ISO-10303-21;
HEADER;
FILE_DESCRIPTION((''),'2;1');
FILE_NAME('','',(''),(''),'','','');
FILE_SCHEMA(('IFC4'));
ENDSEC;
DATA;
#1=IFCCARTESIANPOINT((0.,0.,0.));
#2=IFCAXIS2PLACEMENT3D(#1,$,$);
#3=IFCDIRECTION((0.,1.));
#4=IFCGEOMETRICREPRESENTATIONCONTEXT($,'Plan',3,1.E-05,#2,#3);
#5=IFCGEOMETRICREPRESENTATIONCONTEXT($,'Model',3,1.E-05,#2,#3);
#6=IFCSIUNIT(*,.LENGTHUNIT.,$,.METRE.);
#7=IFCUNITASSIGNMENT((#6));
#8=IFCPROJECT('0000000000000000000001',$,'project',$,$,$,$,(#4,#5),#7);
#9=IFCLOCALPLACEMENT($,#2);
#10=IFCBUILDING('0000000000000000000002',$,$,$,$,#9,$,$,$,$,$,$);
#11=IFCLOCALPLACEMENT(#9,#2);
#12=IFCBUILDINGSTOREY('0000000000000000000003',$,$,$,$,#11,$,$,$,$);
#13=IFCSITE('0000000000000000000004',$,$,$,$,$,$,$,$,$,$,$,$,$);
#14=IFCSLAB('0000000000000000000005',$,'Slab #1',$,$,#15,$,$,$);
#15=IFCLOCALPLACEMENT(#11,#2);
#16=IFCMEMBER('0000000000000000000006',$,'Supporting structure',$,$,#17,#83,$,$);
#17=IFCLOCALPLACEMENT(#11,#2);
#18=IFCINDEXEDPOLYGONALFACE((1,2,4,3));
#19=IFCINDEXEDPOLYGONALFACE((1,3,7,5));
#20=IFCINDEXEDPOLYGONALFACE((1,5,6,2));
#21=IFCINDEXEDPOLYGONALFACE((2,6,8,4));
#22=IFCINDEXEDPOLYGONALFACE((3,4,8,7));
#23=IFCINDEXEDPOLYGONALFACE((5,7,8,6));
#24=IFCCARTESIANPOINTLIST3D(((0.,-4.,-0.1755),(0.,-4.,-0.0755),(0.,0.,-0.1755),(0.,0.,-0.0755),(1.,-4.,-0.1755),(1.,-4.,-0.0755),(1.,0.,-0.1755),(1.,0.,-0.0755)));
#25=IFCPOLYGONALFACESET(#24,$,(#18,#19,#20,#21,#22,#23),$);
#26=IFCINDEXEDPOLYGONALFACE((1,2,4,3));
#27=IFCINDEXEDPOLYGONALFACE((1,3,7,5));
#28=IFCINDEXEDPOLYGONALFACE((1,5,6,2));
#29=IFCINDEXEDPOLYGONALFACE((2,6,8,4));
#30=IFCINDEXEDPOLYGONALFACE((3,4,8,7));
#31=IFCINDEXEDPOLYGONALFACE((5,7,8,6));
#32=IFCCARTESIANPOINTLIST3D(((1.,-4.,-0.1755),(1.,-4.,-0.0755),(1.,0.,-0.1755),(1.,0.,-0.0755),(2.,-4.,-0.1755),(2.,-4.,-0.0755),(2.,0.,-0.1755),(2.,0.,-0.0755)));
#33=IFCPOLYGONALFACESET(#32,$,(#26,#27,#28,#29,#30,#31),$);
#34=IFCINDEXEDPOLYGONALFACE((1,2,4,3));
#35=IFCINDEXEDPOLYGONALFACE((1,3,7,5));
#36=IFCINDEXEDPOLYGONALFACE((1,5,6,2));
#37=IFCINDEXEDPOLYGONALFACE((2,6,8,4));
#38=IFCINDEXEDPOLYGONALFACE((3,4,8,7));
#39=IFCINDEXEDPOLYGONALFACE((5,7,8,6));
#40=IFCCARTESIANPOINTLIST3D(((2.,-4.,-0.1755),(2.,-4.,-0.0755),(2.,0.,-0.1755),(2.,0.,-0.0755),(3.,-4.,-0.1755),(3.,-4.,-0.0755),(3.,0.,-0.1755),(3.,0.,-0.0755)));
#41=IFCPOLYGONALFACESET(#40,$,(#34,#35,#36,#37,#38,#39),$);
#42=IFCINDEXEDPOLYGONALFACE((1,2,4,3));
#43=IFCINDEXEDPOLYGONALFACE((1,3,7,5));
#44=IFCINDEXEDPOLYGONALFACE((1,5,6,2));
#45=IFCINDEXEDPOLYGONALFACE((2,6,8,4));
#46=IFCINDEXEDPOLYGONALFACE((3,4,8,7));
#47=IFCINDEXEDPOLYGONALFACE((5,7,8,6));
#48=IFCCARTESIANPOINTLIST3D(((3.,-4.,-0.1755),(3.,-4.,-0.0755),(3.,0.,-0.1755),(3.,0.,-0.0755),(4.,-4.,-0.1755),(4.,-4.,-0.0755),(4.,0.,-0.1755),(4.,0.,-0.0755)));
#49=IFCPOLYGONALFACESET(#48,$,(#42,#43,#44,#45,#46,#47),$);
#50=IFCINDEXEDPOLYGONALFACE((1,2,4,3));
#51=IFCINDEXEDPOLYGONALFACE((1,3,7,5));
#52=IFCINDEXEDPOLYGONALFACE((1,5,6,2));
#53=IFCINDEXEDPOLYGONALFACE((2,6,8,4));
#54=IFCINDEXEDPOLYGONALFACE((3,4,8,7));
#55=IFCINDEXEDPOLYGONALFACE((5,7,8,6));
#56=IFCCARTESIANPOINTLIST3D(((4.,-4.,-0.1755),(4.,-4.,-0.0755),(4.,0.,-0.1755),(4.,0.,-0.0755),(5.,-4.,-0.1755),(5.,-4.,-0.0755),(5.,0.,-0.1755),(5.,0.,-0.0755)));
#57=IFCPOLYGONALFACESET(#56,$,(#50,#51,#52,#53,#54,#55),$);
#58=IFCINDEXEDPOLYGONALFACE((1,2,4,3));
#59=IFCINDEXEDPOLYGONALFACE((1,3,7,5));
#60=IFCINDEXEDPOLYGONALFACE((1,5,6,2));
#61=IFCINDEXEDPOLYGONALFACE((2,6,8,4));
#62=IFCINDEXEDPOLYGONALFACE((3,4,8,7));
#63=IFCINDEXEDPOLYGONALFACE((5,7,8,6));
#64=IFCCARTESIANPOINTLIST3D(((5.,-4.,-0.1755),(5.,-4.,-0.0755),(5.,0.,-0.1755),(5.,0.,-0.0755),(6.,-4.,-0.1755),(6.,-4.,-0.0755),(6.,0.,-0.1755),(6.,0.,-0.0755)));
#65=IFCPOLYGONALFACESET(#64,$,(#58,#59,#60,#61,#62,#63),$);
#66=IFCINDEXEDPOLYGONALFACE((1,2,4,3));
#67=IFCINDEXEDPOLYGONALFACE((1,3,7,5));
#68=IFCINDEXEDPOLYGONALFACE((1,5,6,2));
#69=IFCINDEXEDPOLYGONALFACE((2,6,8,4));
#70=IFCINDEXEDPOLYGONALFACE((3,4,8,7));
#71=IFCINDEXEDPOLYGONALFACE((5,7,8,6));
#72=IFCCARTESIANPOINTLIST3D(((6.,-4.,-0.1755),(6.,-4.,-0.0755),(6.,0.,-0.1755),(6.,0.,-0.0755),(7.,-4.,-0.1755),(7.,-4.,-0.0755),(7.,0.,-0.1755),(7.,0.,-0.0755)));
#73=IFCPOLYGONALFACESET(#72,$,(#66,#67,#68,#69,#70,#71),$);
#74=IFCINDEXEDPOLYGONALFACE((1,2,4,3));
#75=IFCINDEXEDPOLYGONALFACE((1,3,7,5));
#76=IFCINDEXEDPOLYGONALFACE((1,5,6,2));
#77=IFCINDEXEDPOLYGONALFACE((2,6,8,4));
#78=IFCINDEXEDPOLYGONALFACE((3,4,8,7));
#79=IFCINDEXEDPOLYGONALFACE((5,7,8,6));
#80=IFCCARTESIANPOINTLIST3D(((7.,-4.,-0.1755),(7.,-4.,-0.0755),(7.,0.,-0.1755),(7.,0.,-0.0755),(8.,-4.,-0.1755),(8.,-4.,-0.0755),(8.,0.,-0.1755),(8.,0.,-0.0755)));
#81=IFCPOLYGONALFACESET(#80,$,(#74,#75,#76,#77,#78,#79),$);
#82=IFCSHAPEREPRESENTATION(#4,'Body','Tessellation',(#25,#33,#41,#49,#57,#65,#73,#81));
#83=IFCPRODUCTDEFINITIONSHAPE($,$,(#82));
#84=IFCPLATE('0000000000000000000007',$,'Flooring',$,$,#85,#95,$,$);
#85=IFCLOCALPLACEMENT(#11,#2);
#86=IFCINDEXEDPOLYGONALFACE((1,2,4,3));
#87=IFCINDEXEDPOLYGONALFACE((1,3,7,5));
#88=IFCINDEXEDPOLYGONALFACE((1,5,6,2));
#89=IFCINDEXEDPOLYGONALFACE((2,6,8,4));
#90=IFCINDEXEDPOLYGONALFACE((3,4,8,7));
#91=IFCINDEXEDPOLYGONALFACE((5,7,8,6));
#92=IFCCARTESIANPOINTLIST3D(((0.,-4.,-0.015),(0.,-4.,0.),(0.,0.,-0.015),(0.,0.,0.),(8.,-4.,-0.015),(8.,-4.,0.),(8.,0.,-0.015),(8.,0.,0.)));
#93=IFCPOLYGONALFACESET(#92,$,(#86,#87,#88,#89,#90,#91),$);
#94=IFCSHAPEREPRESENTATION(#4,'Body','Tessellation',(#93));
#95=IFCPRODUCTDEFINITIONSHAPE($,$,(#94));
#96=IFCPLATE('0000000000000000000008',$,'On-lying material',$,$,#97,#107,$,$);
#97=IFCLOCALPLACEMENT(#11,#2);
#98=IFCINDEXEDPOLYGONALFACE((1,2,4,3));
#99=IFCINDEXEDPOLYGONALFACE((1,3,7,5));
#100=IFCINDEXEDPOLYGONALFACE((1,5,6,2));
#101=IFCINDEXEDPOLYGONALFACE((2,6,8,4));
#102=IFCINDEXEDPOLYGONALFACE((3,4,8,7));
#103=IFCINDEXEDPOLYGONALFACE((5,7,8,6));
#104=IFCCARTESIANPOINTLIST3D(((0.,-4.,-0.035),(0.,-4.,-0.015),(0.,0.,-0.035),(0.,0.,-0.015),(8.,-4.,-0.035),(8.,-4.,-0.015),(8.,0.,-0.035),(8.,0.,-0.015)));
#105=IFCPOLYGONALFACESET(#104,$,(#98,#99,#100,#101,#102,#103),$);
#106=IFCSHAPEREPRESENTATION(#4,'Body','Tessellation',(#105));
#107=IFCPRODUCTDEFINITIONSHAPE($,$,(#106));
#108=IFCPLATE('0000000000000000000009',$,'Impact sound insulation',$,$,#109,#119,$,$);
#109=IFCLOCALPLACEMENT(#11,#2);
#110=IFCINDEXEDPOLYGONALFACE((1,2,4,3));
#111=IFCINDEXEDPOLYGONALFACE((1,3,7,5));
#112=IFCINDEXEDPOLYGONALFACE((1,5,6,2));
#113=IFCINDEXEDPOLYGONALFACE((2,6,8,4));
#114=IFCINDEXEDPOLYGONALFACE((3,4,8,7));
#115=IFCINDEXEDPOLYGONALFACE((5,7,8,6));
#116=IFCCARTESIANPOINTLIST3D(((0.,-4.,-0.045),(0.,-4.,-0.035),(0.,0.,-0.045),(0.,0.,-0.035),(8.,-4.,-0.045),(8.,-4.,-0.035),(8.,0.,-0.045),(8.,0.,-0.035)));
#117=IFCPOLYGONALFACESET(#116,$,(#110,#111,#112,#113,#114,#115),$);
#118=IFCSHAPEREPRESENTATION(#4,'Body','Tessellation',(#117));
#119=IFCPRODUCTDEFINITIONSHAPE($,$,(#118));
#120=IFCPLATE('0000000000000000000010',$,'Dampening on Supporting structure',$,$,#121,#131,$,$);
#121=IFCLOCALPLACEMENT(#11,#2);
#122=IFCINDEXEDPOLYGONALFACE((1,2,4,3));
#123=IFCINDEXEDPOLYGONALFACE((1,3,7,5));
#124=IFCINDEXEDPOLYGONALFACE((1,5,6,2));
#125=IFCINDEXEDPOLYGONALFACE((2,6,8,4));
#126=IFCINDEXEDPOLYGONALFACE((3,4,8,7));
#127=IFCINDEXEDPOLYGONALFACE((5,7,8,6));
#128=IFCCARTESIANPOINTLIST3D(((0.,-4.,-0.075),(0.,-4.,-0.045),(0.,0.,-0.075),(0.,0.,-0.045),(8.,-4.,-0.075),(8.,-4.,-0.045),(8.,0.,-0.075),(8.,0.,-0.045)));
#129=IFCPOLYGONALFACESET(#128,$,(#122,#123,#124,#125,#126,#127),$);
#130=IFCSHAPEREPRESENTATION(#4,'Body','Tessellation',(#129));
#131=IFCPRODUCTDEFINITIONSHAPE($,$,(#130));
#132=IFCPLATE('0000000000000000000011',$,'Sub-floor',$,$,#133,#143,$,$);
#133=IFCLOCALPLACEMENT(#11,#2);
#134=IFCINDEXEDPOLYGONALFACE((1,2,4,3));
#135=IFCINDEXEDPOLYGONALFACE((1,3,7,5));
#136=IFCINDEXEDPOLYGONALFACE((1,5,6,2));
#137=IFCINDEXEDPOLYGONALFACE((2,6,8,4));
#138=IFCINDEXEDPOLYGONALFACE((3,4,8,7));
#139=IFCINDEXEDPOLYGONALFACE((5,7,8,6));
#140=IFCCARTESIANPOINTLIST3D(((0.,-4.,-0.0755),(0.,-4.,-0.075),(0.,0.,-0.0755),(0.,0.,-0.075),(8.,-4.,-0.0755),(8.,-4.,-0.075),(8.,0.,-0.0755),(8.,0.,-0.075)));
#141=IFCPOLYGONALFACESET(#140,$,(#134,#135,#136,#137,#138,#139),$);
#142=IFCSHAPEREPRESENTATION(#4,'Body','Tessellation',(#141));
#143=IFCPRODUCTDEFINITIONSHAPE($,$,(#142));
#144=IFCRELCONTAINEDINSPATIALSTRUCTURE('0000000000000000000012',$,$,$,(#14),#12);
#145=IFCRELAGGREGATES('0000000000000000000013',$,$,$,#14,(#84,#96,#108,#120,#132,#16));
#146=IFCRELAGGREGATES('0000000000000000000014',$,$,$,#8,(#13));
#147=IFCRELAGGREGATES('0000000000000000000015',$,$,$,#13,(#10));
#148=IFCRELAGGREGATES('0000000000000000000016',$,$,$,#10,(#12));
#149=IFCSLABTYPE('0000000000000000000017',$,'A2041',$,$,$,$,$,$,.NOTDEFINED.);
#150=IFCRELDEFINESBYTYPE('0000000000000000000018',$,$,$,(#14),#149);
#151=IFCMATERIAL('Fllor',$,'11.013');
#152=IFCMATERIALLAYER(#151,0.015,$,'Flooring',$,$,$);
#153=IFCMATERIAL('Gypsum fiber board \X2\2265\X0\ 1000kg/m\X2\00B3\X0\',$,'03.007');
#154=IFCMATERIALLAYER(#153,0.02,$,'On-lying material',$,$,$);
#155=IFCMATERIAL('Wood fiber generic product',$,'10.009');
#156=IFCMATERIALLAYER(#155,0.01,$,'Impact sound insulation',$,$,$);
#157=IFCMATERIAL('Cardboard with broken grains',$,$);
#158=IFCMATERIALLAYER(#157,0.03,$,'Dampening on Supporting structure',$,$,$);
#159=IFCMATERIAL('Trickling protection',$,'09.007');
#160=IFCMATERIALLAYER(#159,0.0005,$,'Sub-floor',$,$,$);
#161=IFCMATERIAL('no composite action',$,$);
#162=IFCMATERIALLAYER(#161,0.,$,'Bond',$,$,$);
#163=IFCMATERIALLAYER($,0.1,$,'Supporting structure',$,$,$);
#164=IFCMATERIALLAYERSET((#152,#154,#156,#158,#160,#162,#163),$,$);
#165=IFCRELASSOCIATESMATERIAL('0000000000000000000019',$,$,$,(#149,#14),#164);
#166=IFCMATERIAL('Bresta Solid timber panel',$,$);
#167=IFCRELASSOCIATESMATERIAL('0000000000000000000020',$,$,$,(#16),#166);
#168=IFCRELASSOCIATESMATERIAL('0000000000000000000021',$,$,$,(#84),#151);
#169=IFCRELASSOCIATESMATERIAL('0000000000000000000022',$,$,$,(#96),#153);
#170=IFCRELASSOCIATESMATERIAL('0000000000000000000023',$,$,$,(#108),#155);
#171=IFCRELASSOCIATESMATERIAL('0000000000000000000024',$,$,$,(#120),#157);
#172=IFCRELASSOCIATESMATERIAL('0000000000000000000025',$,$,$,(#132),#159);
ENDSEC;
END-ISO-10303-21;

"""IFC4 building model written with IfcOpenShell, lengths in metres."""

from ifc_helpers import new_model, si_unit, direction, frame, frame_2d, origin, origin_with_axes, place, context, project, spatial, rectangle, extrude, material, layer, layer_set, type_object, element, aggregate, save


model = new_model("IFC4")

# Units and contexts
plan_context = context("Plan", 3, precision=1e-05, world=origin(), true_north=direction((0.0, 1.0)))
model_context = context("Model", 3, precision=1e-05, world=origin(), true_north=direction((0.0, 1.0)))
ifc_project = project(units=[si_unit("LENGTHUNIT", "METRE")], contexts=[plan_context, model_context])

# Site, building, storey
site = spatial("IfcSite", under=ifc_project)
building_placement = place(None, origin())
building = spatial("IfcBuilding", under=site, at=building_placement)
storey_placement = place(building_placement, origin())
storey = spatial("IfcBuildingStorey", under=building, at=storey_placement)

# Slab, member, plates
ifc_material_1 = material(Name="Fllor", Category="11.013")
ifc_layer_1 = layer(ifc_material_1, 0.015, Name="Flooring")
ifc_material_2 = material(Name="Gypsum fiber board ≥ 1000kg/m³", Category="03.007")
ifc_layer_2 = layer(ifc_material_2, 0.02, Name="On-lying material")
ifc_material_3 = material(Name="Wood fiber generic product", Category="10.009")
ifc_layer_3 = layer(ifc_material_3, 0.01, Name="Impact sound insulation")
ifc_material_4 = material(Name="Cardboard with broken grains")
ifc_layer_4 = layer(ifc_material_4, 0.03, Name="Dampening on Supporting structure")
ifc_material_5 = material(Name="Trickling protection", Category="09.007")
ifc_layer_5 = layer(ifc_material_5, 0.0005, Name="Sub-floor")
ifc_material_6 = material(Name="no composite action")
ifc_layer_6 = layer(ifc_material_6, 0.0, Name="Bond")
ifc_layer_7 = layer(None, 0.1, Name="Supporting structure")
ifc_layer_set = layer_set([ifc_layer_1, ifc_layer_2, ifc_layer_3, ifc_layer_4, ifc_layer_5, ifc_layer_6, ifc_layer_7])
slab_type = type_object("IfcSlabType", Name="A2041", PredefinedType="NOTDEFINED", material=ifc_layer_set)
slab_placement = place(None, frame((0.0, 0.0, 0.0), z_axis=(0.0, 0.0, -1.0), x_axis=(1.0, 0.0, 0.0)))
slab = element("IfcSlab", 1, at=slab_placement, inside=storey, type_object=slab_type, material=ifc_layer_set, Name="Slab #1")
ifc_material_7 = material(Name="Bresta Solid timber panel")
member_placement = place(slab_placement, origin())
member = element("IfcMember", 2, at=member_placement, material=ifc_material_7, Name="Supporting structure", context=plan_context, shape_type="SweptSolid", body=[
    extrude(rectangle(XDim=1.0, YDim=0.1, at=frame_2d((0.5, 0.05), x_axis=(1.0, 0.0))), frame((0.0, 4.0, 0.0755), z_axis=(0.0, -1.0, 0.0), x_axis=(1.0, 0.0, 0.0)), (0.0, 0.0, 1.0), 4.0),
    extrude(rectangle(XDim=1.0, YDim=0.1, at=frame_2d((0.5, 0.05), x_axis=(1.0, 0.0))), frame((1.0, 4.0, 0.0755), z_axis=(0.0, -1.0, 0.0), x_axis=(1.0, 0.0, 0.0)), (0.0, 0.0, 1.0), 4.0),
    extrude(rectangle(XDim=1.0, YDim=0.1, at=frame_2d((0.5, 0.05), x_axis=(1.0, 0.0))), frame((2.0, 4.0, 0.0755), z_axis=(0.0, -1.0, 0.0), x_axis=(1.0, 0.0, 0.0)), (0.0, 0.0, 1.0), 4.0),
    extrude(rectangle(XDim=1.0, YDim=0.1, at=frame_2d((0.5, 0.05), x_axis=(1.0, 0.0))), frame((3.0, 4.0, 0.0755), z_axis=(0.0, -1.0, 0.0), x_axis=(1.0, 0.0, 0.0)), (0.0, 0.0, 1.0), 4.0),
    extrude(rectangle(XDim=1.0, YDim=0.1, at=frame_2d((0.5, 0.05), x_axis=(1.0, 0.0))), frame((4.0, 4.0, 0.0755), z_axis=(0.0, -1.0, 0.0), x_axis=(1.0, 0.0, 0.0)), (0.0, 0.0, 1.0), 4.0),
    extrude(rectangle(XDim=1.0, YDim=0.1, at=frame_2d((0.5, 0.05), x_axis=(1.0, 0.0))), frame((5.0, 4.0, 0.0755), z_axis=(0.0, -1.0, 0.0), x_axis=(1.0, 0.0, 0.0)), (0.0, 0.0, 1.0), 4.0),
    extrude(rectangle(XDim=1.0, YDim=0.1, at=frame_2d((0.5, 0.05), x_axis=(1.0, 0.0))), frame((6.0, 4.0, 0.0755), z_axis=(0.0, -1.0, 0.0), x_axis=(1.0, 0.0, 0.0)), (0.0, 0.0, 1.0), 4.0),
    extrude(rectangle(XDim=1.0, YDim=0.1, at=frame_2d((0.5, 0.05), x_axis=(1.0, 0.0))), frame((7.0, 4.0, 0.0755), z_axis=(0.0, -1.0, 0.0), x_axis=(1.0, 0.0, 0.0)), (0.0, 0.0, 1.0), 4.0),
])
plate_1_placement = place(slab_placement, origin())
plate_1 = element("IfcPlate", 3, at=plate_1_placement, material=ifc_material_1, Name="Flooring", context=plan_context, shape_type="SweptSolid", body=[
    extrude(rectangle(XDim=8.0, YDim=4.0, at=frame_2d((4.0, 2.0), x_axis=(1.0, 0.0))), origin_with_axes(), (0.0, 0.0, 1.0), 0.015),
])
plate_2_placement = place(slab_placement, origin())
plate_2 = element("IfcPlate", 4, at=plate_2_placement, material=ifc_material_2, Name="On-lying material", context=plan_context, shape_type="SweptSolid", body=[
    extrude(rectangle(XDim=8.0, YDim=4.0, at=frame_2d((4.0, 2.0), x_axis=(1.0, 0.0))), frame((0.0, 0.0, 0.015), z_axis=(0.0, 0.0, 1.0), x_axis=(1.0, 0.0, 0.0)), (0.0, 0.0, 1.0), 0.02),
])
plate_3_placement = place(slab_placement, origin())
plate_3 = element("IfcPlate", 5, at=plate_3_placement, material=ifc_material_3, Name="Impact sound insulation", context=plan_context, shape_type="SweptSolid", body=[
    extrude(rectangle(XDim=8.0, YDim=4.0, at=frame_2d((4.0, 2.0), x_axis=(1.0, 0.0))), frame((0.0, 0.0, 0.035), z_axis=(0.0, 0.0, 1.0), x_axis=(1.0, 0.0, 0.0)), (0.0, 0.0, 1.0), 0.01),
])
plate_4_placement = place(slab_placement, origin())
plate_4 = element("IfcPlate", 6, at=plate_4_placement, material=ifc_material_4, Name="Dampening on Supporting structure", context=plan_context, shape_type="SweptSolid", body=[
    extrude(rectangle(XDim=8.0, YDim=4.0, at=frame_2d((4.0, 2.0), x_axis=(1.0, 0.0))), frame((0.0, 0.0, 0.045), z_axis=(0.0, 0.0, 1.0), x_axis=(1.0, 0.0, 0.0)), (0.0, 0.0, 1.0), 0.03),
])
plate_5_placement = place(slab_placement, origin())
plate_5 = element("IfcPlate", 7, at=plate_5_placement, material=ifc_material_5, Name="Sub-floor", context=plan_context, shape_type="SweptSolid", body=[
    extrude(rectangle(XDim=8.0, YDim=4.0, at=frame_2d((4.0, 2.0), x_axis=(1.0, 0.0))), frame((0.0, 0.0, 0.075), z_axis=(0.0, 0.0, 1.0), x_axis=(1.0, 0.0, 0.0)), (0.0, 0.0, 1.0), 0.0005),
])
aggregate(slab, [plate_1, plate_2, plate_3, plate_4, plate_5, member])

save(model, "model.ifc")
